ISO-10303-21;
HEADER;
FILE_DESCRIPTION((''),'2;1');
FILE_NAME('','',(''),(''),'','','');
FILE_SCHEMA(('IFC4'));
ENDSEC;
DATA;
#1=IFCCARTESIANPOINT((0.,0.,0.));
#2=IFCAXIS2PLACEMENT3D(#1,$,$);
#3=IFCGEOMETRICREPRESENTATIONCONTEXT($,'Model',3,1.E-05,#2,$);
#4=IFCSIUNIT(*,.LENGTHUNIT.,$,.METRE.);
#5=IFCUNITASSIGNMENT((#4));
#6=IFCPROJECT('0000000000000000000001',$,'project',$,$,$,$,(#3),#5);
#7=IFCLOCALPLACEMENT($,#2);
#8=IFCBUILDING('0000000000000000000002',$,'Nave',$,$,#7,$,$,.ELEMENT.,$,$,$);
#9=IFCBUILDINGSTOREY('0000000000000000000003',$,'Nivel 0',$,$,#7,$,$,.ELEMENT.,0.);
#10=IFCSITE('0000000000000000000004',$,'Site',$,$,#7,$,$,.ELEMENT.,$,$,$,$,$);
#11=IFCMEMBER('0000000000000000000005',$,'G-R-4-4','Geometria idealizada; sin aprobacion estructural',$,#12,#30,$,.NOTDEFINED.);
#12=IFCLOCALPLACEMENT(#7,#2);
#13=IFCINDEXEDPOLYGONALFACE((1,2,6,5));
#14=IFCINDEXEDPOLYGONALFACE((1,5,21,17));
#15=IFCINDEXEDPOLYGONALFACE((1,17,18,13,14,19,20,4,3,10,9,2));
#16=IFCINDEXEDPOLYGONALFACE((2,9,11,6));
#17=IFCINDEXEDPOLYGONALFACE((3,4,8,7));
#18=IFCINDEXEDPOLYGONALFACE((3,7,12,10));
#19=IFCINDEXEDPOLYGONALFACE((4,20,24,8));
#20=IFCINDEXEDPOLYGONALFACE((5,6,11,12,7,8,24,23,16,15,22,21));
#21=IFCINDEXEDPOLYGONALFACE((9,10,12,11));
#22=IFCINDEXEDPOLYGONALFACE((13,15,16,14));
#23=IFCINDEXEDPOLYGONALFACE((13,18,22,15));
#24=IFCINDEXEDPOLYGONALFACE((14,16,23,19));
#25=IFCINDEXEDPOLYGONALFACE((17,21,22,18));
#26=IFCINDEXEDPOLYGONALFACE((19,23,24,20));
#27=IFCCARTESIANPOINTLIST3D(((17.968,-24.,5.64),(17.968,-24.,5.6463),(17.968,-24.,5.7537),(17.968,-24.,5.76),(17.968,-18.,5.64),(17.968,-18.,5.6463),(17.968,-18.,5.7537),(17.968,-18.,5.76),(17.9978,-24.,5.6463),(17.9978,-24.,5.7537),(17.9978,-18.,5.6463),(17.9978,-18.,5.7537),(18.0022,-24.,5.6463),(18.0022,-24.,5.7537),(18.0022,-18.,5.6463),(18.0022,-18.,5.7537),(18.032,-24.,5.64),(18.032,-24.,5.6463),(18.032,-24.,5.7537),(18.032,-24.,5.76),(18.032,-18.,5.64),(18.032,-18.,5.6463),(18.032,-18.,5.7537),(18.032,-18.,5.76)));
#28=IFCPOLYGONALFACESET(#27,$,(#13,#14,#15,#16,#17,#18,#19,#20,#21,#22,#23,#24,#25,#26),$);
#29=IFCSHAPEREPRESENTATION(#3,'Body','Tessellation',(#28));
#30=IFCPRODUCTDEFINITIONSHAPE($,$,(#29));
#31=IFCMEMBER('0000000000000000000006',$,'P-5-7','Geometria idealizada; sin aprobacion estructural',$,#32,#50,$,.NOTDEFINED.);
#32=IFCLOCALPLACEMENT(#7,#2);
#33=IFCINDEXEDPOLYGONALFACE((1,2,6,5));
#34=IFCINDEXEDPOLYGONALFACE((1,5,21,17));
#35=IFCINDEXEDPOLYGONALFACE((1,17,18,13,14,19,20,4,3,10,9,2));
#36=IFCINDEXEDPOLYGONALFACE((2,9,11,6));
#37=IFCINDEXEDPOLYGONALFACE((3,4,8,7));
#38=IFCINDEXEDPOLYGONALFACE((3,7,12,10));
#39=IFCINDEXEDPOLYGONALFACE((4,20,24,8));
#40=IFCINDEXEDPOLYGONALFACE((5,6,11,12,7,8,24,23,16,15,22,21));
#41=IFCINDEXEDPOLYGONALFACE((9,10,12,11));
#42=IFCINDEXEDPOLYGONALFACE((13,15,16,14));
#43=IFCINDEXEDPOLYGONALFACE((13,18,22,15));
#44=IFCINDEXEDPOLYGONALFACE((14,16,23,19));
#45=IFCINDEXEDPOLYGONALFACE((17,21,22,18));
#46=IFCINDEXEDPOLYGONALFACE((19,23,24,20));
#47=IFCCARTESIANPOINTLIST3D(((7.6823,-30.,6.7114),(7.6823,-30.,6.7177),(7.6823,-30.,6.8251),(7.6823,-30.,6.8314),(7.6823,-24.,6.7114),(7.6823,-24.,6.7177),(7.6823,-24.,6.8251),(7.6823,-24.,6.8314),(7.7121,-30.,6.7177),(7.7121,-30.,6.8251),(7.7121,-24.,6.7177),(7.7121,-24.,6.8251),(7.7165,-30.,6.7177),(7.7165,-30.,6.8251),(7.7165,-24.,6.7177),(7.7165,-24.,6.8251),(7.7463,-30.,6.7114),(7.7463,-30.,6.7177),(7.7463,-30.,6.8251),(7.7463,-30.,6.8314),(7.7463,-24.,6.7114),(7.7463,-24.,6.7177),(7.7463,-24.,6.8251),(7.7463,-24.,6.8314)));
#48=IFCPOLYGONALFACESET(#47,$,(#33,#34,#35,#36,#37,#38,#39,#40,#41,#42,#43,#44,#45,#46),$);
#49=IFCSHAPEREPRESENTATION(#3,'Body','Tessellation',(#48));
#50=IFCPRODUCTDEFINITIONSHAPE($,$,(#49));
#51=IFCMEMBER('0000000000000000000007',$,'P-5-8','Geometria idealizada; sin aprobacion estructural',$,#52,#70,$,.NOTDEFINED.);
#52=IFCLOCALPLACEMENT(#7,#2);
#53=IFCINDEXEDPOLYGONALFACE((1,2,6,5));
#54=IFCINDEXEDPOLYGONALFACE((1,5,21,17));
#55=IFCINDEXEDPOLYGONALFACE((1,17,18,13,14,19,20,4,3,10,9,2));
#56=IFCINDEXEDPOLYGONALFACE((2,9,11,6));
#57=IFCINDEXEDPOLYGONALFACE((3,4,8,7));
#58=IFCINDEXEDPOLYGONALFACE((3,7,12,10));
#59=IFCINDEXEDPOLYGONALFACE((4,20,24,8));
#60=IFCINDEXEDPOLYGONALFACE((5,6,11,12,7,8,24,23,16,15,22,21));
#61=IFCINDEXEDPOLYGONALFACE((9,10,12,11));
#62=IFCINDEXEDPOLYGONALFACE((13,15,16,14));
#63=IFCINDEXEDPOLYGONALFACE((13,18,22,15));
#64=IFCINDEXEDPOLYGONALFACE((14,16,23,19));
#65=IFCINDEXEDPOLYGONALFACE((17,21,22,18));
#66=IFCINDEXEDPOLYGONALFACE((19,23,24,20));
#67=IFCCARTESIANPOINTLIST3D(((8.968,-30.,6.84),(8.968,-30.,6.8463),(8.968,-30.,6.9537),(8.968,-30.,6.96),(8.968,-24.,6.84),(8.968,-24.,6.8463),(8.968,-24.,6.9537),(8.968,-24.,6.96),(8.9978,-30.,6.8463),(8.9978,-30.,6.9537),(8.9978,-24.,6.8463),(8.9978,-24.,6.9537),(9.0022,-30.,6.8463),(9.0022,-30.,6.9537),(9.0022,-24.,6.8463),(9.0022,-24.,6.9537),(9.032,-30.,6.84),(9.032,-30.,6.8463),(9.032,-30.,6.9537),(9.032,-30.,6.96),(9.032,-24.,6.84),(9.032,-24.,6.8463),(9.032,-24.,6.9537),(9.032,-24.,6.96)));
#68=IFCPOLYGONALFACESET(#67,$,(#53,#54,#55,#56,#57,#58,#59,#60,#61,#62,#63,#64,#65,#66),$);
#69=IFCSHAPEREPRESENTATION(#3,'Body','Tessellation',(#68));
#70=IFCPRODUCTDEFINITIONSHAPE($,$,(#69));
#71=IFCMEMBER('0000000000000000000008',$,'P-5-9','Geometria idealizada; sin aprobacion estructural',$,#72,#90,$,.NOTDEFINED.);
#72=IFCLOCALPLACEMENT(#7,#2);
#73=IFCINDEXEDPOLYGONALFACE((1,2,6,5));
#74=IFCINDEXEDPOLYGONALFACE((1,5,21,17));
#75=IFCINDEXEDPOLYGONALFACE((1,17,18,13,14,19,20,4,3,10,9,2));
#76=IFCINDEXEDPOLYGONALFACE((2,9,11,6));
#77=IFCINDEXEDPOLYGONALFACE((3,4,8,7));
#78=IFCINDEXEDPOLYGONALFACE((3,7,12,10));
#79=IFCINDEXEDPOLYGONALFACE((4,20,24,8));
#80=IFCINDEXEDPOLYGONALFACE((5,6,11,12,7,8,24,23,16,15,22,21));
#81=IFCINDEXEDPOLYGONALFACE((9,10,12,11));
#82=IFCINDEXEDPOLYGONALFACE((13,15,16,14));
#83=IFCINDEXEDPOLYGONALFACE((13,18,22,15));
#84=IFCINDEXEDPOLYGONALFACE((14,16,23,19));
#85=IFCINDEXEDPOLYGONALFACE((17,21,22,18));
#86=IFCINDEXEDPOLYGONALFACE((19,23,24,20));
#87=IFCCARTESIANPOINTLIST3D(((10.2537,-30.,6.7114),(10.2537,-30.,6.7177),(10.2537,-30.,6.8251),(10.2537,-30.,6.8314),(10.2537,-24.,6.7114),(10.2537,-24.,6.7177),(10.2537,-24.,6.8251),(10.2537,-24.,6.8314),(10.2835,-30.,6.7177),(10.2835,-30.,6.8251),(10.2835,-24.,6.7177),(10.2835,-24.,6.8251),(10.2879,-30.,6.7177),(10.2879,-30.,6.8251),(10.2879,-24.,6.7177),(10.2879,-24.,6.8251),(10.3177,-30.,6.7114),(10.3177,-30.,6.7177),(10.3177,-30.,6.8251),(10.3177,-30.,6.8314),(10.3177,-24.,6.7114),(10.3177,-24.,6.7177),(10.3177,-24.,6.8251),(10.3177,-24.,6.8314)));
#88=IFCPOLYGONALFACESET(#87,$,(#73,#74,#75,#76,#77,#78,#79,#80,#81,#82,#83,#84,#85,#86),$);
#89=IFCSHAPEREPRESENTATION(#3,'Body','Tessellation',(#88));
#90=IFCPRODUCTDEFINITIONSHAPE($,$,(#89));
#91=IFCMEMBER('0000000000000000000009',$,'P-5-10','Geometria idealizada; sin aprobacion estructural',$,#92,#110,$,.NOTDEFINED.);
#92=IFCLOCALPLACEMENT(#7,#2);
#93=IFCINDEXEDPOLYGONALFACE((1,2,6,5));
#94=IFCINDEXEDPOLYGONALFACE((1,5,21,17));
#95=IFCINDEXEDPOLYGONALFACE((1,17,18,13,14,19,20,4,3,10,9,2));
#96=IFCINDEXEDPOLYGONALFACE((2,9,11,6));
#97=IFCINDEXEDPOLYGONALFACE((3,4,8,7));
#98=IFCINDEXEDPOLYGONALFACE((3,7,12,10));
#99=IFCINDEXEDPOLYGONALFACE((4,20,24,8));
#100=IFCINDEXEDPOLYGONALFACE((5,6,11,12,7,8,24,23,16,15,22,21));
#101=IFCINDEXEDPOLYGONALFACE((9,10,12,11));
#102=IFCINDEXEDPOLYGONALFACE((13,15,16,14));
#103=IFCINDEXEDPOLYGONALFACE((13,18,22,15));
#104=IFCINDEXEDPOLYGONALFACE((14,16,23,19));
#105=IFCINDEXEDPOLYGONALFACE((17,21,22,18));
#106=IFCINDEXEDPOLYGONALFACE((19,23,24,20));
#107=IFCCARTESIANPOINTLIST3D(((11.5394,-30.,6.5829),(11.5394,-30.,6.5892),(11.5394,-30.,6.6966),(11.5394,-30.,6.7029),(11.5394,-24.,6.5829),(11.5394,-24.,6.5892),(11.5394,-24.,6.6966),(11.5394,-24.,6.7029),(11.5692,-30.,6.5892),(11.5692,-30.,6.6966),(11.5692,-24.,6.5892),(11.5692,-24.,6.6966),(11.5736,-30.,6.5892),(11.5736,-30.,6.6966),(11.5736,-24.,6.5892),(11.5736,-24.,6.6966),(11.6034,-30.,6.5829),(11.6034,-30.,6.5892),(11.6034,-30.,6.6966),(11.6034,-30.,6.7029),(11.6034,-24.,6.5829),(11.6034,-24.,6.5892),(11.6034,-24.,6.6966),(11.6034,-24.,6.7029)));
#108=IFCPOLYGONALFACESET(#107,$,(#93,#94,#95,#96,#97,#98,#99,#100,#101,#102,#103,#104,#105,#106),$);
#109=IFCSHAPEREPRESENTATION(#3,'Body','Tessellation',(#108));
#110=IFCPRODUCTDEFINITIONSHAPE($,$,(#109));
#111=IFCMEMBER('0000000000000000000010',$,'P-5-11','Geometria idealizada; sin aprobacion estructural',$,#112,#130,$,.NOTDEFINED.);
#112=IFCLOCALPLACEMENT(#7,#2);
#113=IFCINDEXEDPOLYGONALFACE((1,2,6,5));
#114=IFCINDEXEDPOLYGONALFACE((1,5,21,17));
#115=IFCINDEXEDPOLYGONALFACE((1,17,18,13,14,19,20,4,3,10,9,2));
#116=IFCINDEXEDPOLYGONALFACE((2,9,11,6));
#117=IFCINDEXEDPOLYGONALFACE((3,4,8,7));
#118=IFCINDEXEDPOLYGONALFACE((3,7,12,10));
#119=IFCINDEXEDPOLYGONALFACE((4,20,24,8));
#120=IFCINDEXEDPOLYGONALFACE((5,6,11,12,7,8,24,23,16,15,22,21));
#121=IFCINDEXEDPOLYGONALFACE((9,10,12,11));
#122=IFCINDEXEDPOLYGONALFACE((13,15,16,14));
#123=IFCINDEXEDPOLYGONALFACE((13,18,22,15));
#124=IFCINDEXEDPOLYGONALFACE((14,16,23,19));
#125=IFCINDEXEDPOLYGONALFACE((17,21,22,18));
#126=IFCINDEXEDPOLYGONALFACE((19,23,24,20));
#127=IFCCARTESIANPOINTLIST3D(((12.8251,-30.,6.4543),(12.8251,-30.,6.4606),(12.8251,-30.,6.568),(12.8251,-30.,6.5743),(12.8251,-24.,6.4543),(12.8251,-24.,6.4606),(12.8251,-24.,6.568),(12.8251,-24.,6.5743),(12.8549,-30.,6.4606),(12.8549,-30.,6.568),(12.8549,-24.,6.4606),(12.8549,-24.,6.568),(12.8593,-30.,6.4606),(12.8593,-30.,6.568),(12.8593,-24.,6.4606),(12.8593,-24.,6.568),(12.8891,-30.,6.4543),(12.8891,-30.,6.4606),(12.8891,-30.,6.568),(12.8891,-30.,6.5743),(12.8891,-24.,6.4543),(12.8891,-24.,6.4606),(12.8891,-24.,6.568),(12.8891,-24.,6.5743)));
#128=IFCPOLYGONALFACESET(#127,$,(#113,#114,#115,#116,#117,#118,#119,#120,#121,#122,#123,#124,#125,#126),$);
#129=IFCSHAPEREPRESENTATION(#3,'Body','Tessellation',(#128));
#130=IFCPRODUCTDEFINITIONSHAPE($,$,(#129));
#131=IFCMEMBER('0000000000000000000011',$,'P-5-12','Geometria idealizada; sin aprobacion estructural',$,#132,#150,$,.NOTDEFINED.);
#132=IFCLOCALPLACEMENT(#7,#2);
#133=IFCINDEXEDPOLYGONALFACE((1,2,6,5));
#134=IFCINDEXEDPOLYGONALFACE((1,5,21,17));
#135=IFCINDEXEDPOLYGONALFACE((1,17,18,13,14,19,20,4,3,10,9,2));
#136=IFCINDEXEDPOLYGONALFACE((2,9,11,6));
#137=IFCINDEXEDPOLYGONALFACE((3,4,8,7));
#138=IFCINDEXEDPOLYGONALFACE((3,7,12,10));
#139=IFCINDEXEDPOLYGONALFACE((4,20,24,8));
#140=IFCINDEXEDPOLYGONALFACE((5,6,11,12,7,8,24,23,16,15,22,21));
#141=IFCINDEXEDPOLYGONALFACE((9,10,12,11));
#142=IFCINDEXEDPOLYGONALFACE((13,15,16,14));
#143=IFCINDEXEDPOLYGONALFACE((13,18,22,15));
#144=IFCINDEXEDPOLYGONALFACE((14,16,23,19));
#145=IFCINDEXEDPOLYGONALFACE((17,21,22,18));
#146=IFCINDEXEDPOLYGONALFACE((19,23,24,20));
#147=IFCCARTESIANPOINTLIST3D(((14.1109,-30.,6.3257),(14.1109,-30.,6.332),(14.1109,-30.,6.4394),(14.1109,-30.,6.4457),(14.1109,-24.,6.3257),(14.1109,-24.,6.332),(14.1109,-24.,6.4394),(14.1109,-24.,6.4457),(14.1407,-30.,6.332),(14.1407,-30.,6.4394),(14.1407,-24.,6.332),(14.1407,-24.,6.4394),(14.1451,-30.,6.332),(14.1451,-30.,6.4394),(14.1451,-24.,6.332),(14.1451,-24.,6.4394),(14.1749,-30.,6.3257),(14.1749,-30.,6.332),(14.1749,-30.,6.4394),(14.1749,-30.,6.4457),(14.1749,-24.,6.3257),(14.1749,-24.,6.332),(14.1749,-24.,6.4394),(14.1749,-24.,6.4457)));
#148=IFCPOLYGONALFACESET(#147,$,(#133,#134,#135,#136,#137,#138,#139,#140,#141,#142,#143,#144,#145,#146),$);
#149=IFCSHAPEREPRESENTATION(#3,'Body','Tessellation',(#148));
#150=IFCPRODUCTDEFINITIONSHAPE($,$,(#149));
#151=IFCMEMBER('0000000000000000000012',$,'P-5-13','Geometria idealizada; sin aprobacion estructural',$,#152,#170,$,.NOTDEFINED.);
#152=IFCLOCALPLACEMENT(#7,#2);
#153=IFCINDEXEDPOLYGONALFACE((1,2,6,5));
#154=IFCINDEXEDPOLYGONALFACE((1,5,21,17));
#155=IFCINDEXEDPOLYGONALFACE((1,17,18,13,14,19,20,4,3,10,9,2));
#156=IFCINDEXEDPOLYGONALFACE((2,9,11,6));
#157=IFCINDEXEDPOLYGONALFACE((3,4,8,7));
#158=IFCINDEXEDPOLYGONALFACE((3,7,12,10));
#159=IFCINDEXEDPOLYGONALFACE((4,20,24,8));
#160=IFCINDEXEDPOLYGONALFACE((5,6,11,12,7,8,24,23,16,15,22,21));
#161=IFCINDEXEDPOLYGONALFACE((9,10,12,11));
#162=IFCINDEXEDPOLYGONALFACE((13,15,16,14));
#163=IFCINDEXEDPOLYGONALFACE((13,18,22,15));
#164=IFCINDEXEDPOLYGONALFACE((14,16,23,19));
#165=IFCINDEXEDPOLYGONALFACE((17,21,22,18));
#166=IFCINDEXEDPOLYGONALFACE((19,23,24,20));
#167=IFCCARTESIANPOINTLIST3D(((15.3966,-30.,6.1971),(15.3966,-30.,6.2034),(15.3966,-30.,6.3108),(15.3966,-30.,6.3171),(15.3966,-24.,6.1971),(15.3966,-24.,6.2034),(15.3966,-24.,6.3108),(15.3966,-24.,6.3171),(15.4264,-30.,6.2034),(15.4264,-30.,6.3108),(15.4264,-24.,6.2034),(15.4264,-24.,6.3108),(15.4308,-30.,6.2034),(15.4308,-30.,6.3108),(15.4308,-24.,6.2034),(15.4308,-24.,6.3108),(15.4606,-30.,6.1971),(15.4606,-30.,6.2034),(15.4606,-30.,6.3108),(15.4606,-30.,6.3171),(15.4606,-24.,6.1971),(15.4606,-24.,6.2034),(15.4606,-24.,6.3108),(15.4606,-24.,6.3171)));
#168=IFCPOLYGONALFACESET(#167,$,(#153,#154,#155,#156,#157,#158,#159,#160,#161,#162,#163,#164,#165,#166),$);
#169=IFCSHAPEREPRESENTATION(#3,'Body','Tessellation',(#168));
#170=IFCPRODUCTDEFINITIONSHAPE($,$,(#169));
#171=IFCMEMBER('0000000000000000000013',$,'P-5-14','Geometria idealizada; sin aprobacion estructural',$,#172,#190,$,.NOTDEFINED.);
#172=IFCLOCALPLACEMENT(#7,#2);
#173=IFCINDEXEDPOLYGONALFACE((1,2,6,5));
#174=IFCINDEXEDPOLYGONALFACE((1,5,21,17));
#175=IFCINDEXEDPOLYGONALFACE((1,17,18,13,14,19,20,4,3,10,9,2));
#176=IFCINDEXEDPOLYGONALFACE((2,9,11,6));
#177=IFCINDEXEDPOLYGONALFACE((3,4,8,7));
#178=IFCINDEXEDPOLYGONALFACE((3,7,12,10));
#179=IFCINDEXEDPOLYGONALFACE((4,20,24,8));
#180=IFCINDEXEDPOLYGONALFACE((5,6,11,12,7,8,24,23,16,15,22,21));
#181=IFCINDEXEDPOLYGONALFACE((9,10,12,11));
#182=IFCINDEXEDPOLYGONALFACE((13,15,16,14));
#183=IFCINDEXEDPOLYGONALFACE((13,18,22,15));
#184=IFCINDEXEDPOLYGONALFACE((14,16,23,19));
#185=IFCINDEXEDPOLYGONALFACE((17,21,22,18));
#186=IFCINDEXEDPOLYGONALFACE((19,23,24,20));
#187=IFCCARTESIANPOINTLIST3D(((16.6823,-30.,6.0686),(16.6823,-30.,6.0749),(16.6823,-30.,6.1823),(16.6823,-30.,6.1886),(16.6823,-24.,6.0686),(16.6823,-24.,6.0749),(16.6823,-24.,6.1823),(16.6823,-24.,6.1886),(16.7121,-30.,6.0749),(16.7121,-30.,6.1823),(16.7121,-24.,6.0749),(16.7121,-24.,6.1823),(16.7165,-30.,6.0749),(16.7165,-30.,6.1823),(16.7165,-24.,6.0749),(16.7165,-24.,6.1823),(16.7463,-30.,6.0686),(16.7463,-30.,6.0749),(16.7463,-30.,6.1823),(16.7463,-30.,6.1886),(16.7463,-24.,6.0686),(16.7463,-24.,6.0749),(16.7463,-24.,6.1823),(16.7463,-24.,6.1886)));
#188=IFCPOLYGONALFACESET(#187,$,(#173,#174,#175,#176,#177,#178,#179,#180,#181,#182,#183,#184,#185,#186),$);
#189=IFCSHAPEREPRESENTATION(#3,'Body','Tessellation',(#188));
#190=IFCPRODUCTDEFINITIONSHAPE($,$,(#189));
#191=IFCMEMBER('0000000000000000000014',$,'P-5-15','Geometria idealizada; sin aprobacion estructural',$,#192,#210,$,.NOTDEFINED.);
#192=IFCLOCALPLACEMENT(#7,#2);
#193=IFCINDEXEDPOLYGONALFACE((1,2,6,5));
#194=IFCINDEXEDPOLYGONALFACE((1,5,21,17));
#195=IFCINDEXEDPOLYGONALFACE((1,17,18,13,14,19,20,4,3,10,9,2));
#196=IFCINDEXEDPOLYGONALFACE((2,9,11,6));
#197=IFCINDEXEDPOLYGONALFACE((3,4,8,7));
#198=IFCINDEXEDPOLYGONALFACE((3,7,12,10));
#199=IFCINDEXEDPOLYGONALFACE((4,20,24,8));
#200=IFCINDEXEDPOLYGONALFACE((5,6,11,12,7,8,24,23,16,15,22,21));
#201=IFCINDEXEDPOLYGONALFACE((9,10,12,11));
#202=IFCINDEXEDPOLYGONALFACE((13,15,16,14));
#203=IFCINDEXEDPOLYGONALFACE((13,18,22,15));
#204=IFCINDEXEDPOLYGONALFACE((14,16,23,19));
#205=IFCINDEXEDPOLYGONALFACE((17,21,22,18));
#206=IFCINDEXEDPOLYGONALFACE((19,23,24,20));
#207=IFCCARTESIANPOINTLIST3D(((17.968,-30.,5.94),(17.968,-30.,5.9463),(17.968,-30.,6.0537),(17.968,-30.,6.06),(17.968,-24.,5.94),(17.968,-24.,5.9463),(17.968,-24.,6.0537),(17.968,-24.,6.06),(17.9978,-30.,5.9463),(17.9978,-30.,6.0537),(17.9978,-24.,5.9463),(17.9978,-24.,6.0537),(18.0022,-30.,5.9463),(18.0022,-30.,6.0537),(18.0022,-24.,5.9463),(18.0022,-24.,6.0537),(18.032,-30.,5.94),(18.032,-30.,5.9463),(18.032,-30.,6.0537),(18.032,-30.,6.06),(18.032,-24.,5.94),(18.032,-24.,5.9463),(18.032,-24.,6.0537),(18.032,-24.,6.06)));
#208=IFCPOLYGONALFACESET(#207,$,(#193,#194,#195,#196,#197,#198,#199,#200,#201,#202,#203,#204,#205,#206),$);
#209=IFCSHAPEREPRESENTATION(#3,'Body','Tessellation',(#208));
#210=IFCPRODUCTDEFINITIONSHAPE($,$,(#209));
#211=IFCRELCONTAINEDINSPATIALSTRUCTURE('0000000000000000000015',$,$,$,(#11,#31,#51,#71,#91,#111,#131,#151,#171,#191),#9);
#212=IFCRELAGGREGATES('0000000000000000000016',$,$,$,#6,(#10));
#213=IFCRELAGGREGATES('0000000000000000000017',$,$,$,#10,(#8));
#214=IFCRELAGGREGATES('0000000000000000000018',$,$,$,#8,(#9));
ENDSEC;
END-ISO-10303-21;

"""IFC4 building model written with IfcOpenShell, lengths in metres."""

from ifc_helpers import new_model, si_unit, frame, origin, place, context, project, spatial, polyline, outline, extrude, element, save


model = new_model("IFC4")

# Units and contexts
model_context = context("Model", 3, precision=1e-05, world=origin())
ifc_project = project(units=[si_unit("LENGTHUNIT", "METRE")], contexts=[model_context])

# Site, building, storey
placement = place(None, origin())
site = spatial("IfcSite", under=ifc_project, at=placement, Name="Site", CompositionType="ELEMENT")
building = spatial("IfcBuilding", under=site, at=placement, Name="Nave", CompositionType="ELEMENT")
storey = spatial("IfcBuildingStorey", under=building, at=placement, Name="Nivel 0", CompositionType="ELEMENT", Elevation=0.0)

# Members
for number, where, z_axis, x_axis, name in (
    (1, (18.0, -18.0, 5.7), (0.0, -1.0, 0.0), (1.0, 0.0, 0.0), "G-R-4-4"),
    (2, (7.7143, -24.0, 6.7714), (0.0, -1.0, 0.0), (1.0, 0.0, 0.0), "P-5-7"),
    (3, (9.0, -24.0, 6.9), (0.0, -1.0, 0.0), (1.0, 0.0, 0.0), "P-5-8"),
    (4, (10.2857, -24.0, 6.7714), (0.0, -1.0, 0.0), (1.0, 0.0, 0.0), "P-5-9"),
    (5, (11.5714, -24.0, 6.6429), (0.0, -1.0, 0.0), (1.0, 0.0, 0.0), "P-5-10"),
    (6, (12.8571, -24.0, 6.5143), (0.0, -1.0, 0.0), (1.0, 0.0, 0.0), "P-5-11"),
    (7, (14.1429, -24.0, 6.3857), (0.0, -1.0, 0.0), (1.0, 0.0, 0.0), "P-5-12"),
    (8, (15.4286, -24.0, 6.2571), (0.0, -1.0, 0.0), (1.0, 0.0, 0.0), "P-5-13"),
    (9, (16.7143, -24.0, 6.1286), (0.0, -1.0, 0.0), (1.0, 0.0, 0.0), "P-5-14"),
    (10, (18.0, -24.0, 6.0), (0.0, -1.0, 0.0), (1.0, 0.0, 0.0), "P-5-15"),
):
    element("IfcMember", number, at=place(placement, frame(where, z_axis=z_axis, x_axis=x_axis)), inside=storey, Name=name, Description="Geometria idealizada; sin aprobacion estructural", PredefinedType="NOTDEFINED", context=model_context, shape_type="SweptSolid", body=[
        extrude(outline(polyline([(-0.032, -0.06), (0.032, -0.06), (0.032, -0.0537), (0.0022, -0.0537), (0.0022, 0.0537), (0.032, 0.0537), (0.032, 0.06), (-0.032, 0.06), (-0.032, 0.0537), (-0.0022, 0.0537), (-0.0022, -0.0537), (-0.032, -0.0537), (-0.032, -0.06)])), origin(), (0.0, 0.0, 1.0), 6.0),
    ])

save(model, "model.ifc")
